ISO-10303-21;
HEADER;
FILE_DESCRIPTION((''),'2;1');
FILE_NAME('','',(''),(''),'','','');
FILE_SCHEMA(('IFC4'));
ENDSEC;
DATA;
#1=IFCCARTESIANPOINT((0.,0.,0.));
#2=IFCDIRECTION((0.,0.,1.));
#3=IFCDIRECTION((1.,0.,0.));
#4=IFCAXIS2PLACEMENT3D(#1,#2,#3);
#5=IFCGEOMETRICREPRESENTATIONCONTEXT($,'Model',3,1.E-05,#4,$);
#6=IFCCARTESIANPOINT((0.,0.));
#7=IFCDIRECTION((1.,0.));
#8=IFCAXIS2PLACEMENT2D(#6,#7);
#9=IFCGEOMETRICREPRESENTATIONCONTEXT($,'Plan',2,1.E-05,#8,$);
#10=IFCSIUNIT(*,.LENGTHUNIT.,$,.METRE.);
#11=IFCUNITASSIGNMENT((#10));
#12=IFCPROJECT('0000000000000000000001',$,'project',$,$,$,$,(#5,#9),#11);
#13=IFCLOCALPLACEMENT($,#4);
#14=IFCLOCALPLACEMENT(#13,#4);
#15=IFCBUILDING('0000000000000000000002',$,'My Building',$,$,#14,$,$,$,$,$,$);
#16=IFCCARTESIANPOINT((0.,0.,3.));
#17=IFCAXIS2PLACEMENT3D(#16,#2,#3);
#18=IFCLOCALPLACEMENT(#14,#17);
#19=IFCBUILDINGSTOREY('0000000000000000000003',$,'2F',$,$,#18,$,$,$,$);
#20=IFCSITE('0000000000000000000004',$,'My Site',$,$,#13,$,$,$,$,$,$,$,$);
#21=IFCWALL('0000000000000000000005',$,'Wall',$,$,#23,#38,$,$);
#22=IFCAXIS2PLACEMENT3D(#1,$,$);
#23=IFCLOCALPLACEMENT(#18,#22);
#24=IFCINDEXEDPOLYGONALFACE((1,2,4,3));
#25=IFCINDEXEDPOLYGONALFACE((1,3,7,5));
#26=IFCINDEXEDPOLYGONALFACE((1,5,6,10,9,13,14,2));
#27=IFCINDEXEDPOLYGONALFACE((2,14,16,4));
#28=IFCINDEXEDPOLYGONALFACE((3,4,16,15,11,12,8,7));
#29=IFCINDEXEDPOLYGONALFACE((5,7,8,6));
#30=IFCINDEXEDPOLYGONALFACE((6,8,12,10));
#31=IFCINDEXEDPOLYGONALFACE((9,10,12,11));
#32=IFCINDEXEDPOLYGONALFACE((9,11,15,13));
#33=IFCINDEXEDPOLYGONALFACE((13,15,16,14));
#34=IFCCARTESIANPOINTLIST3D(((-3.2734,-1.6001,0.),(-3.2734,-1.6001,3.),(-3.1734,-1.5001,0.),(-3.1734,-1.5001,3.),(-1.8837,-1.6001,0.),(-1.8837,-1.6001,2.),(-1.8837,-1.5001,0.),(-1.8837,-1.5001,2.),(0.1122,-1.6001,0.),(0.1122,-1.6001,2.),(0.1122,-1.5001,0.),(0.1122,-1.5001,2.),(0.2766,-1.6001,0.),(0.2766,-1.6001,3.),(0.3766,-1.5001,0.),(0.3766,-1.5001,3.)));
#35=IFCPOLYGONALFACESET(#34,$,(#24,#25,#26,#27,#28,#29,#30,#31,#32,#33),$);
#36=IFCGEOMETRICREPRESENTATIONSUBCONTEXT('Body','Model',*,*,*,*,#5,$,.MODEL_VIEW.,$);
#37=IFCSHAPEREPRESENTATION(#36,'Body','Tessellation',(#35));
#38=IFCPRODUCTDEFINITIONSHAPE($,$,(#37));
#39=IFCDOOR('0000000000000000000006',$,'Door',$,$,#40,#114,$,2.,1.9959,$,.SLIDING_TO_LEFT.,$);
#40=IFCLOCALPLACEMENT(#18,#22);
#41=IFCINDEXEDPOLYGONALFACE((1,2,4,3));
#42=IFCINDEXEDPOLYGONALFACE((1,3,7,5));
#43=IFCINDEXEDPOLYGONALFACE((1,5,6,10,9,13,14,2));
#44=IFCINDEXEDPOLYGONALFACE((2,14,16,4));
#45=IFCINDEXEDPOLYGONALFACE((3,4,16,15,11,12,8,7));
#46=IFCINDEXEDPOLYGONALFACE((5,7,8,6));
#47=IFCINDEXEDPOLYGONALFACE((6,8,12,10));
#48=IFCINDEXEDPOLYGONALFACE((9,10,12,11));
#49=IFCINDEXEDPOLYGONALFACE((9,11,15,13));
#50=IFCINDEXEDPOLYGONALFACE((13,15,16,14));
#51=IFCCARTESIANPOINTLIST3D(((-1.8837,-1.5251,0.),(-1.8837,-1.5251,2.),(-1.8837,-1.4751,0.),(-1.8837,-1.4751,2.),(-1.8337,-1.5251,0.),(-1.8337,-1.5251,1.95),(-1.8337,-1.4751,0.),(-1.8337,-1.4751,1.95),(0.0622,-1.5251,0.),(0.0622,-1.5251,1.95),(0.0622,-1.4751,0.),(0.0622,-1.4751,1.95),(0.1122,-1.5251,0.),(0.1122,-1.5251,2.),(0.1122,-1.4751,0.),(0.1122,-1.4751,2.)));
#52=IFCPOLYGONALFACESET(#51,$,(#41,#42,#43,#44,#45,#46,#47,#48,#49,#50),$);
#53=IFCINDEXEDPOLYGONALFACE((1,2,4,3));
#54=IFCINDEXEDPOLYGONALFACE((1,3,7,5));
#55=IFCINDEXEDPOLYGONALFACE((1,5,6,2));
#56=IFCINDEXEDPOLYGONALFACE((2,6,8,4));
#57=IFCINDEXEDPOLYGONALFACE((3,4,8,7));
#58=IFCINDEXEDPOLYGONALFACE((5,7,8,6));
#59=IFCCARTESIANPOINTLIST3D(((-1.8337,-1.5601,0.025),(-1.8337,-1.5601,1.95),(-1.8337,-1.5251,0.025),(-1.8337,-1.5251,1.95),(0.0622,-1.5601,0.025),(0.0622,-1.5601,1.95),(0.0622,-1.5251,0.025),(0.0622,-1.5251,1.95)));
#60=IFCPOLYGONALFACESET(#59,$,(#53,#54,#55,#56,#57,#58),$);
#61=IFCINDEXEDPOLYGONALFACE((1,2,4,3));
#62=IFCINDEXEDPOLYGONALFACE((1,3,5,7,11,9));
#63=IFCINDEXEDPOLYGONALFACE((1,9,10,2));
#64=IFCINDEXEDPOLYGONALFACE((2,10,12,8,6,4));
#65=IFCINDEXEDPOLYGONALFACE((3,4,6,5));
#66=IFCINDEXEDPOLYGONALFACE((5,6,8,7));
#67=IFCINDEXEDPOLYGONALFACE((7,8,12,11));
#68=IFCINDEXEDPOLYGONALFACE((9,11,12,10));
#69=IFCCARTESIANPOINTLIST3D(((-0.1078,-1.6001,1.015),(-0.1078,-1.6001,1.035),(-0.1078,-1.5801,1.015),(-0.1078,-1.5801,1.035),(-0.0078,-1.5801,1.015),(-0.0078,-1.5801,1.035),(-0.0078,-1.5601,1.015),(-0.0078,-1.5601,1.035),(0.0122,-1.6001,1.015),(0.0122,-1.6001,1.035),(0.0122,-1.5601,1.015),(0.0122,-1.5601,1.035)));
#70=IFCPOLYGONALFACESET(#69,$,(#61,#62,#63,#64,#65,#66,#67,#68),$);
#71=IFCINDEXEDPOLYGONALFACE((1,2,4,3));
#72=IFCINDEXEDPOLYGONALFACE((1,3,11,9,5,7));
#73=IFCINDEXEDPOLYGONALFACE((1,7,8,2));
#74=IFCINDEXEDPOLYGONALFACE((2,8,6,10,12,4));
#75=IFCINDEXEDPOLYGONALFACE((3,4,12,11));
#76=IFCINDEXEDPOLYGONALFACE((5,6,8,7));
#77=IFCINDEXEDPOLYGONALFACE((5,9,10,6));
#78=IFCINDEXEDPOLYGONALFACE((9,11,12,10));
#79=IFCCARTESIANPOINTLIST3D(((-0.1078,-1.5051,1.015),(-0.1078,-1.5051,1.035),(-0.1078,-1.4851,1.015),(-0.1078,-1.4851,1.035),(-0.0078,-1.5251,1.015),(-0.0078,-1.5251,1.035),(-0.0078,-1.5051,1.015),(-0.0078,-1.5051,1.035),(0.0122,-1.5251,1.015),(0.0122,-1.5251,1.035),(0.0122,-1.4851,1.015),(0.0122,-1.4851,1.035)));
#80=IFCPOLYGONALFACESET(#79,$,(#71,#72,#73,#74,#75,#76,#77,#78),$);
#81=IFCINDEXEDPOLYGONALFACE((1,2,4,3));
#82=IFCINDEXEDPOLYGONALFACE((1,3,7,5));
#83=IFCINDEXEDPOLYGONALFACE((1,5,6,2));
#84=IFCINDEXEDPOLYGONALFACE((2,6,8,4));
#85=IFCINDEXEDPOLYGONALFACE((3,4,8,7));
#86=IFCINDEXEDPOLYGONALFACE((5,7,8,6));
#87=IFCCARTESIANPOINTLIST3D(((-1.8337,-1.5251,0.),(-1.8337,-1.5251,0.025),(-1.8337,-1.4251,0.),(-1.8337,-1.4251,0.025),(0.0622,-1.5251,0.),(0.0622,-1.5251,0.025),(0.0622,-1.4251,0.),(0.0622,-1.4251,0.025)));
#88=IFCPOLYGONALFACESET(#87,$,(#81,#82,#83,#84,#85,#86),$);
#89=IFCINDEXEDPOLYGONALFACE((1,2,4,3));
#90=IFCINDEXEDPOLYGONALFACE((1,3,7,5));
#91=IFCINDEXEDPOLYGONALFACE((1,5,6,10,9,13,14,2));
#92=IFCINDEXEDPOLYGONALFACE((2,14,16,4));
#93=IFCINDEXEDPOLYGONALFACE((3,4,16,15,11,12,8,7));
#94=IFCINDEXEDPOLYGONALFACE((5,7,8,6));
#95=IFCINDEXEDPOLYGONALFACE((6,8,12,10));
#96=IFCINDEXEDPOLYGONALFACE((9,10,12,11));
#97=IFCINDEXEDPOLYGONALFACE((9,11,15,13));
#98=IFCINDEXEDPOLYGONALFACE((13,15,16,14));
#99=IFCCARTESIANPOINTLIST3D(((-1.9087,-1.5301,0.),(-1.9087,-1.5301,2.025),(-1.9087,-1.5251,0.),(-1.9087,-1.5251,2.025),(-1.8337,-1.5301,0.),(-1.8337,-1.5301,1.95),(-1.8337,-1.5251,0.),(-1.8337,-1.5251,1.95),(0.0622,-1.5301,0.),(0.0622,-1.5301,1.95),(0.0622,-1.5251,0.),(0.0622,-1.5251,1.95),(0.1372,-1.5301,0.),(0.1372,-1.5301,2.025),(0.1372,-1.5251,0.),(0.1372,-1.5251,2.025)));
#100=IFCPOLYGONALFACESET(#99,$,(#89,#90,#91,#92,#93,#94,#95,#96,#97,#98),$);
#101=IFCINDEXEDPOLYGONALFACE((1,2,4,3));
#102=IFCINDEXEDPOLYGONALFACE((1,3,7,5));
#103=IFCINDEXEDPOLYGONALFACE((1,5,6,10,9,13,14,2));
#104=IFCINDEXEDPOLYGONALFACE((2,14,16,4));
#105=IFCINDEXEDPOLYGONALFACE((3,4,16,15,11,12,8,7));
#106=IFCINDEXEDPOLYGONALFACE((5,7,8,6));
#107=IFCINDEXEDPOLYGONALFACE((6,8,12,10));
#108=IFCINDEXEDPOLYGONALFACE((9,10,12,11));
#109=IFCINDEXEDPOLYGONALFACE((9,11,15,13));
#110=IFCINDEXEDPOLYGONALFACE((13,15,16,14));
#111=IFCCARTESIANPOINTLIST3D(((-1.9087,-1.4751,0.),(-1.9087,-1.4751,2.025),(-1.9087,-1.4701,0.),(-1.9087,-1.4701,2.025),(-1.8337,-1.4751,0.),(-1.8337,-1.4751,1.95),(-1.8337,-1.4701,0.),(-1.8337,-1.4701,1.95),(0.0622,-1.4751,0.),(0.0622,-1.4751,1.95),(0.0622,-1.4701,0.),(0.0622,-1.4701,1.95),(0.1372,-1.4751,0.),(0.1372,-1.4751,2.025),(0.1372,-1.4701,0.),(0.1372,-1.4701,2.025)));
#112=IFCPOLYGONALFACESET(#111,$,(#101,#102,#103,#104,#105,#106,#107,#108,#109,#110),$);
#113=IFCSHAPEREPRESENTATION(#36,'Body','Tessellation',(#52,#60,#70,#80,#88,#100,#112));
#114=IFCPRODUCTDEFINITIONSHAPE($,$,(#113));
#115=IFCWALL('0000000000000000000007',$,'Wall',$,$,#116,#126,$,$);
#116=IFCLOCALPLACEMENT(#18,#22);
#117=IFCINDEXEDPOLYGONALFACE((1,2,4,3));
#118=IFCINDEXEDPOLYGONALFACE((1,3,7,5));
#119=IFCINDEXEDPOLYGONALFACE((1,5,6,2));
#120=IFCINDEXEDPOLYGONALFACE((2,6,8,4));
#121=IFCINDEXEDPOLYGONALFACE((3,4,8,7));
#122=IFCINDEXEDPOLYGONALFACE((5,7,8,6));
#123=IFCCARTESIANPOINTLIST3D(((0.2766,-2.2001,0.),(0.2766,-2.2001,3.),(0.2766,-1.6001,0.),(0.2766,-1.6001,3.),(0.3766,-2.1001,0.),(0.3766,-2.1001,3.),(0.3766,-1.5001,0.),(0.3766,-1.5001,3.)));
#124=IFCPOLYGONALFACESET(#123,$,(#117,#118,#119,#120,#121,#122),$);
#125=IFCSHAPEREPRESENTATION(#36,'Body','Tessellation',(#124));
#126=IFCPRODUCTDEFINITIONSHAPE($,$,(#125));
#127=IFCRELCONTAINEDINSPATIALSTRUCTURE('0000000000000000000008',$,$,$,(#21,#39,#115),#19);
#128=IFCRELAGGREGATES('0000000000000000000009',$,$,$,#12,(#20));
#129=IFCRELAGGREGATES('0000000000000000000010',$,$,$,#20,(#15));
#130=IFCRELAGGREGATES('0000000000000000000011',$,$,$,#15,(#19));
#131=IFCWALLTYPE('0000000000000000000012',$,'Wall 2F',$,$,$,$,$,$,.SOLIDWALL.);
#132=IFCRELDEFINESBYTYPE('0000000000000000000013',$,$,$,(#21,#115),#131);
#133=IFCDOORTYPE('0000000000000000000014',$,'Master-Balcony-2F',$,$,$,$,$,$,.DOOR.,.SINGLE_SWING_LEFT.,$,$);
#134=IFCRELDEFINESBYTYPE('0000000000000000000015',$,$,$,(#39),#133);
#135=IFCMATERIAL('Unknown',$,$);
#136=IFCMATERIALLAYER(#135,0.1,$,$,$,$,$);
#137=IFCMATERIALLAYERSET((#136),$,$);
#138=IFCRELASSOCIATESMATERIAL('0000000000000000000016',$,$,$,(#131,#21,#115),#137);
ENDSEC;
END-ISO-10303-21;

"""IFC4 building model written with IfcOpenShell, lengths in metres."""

from ifc_helpers import new_model, entity, si_unit, frame, origin_with_axes, origin_2d_with_axis, place, context, subcontext, project, spatial, line, indexed_curve, outline, extrude, shape, source, transform, mapped, material, layer, layer_set, layer_usage, type_object, type_shapes, element, fill, save


model = new_model("IFC4")

# Units and contexts
model_context = context("Model", 3, precision=1e-05, world=origin_with_axes())
plan_context = context("Plan", 2, precision=1e-05, world=origin_2d_with_axis())
body_context_1 = subcontext(model_context, "Body", "Model", "MODEL_VIEW")
body_context_2 = subcontext(plan_context, "Body", "Plan", "PLAN_VIEW")
ifc_project = project(units=[si_unit("LENGTHUNIT", "METRE")], contexts=[model_context, plan_context])

# Site, building, storey
site_placement = place(None, origin_with_axes())
site = spatial("IfcSite", under=ifc_project, at=site_placement, Name="My Site")
building_placement = place(site_placement, origin_with_axes())
building = spatial("IfcBuilding", under=site, at=building_placement, Name="My Building")
storey_placement = place(building_placement, frame((0.0, 0.0, 3.0), z_axis=(0.0, 0.0, 1.0), x_axis=(1.0, 0.0, 0.0)))
storey = spatial("IfcBuildingStorey", under=building, at=storey_placement, Name="2F")

# Shared definitions
ifc_material = material(Name="Unknown")

# Wall, opening, door
ifc_layer = layer(ifc_material, 0.1)
ifc_layer_set = layer_set([ifc_layer])
ifc_layer_usage_1 = layer_usage(ifc_layer_set, "AXIS2", "POSITIVE", 0.0)
wall_type = type_object("IfcWallType", Name="Wall 2F", PredefinedType="SOLIDWALL", material=ifc_layer_set)
wall_1_placement = place(storey_placement, frame((-3.2734, -1.6001, 0.0), z_axis=(0.0, 0.0, 1.0), x_axis=(1.0, 0.0, 0.0)))
wall_1 = element("IfcWall", 1, at=wall_1_placement, inside=storey, type_object=wall_type, material=ifc_layer_usage_1, Name="Wall", context=body_context_1, shape_type="SweptSolid", body=[
    extrude(outline(indexed_curve([(0.0, 0.0), (0.1, 0.1), (3.65, 0.1), (3.55, 0.0)], segments=[line(1, 2, 3, 4, 1)])), origin_with_axes(), (0.0, 0.0, 1.0), 3.0),
])
shared_shape_1 = source(origin_with_axes(), body_context_1, "Body", "SweptSolid", [
    extrude(outline(indexed_curve([(0.0, 0.0), (1.9959, 0.0), (1.9959, 2.0), (0.0, 2.0)], segments=[line(1, 2, 3, 4, 1)])), frame((0.0, -0.6, 0.0), z_axis=(0.0, -1.0, 0.0), x_axis=(1.0, 0.0, 0.0)), (0.0, 0.0, -1.0), 1.2),
])
opening_1_placement = place(wall_1_placement, frame((1.3897, 0.075, 0.0), z_axis=(0.0, 0.0, 1.0), x_axis=(1.0, 0.0, 0.0)))
opening_1 = element("IfcOpeningElement", 2, at=opening_1_placement, cuts=wall_1, PredefinedType="OPENING", context=body_context_1, shape_type="MappedRepresentation", body=[
    mapped(shared_shape_1, transform((0.0, 0.0, 0.0), x_axis=(1.0, 0.0, 0.0), y_axis=(0.0, 1.0, 0.0), z_axis=(0.0, 0.0, 1.0), scale=1.0)),
])
door_type_1 = type_object("IfcDoorType", Name="Master-Balcony-2F", OperationType="SINGLE_SWING_LEFT", PredefinedType="DOOR")
shared_shape_2 = source(origin_with_axes(), body_context_1, "Body", "SweptSolid", [
    extrude(outline(indexed_curve([(0.0, 0.0), (0.0, 2.0), (1.9959, 2.0), (1.9959, 0.0), (1.9459, 0.0), (1.9459, 1.95), (0.05, 1.95), (0.05, 0.0)], segments=[line(1, 2, 3, 4, 5, 6, 7, 8, 1)])), frame((0.0, 0.0, 0.0), z_axis=(0.0, -1.0, 0.0), x_axis=(1.0, 0.0, 0.0)), (0.0, 0.0, -1.0), 0.05),
    extrude(outline(indexed_curve([(0.0, 0.0), (1.8959, 0.0), (1.8959, 0.035), (0.0, 0.035)], segments=[line(1, 2, 3, 4, 1)])), frame((0.05, -0.035, 0.025), z_axis=(0.0, 0.0, 1.0), x_axis=(1.0, 0.0, 0.0)), (0.0, 0.0, 1.0), 1.925),
    extrude(outline(indexed_curve([(0.0, 0.0), (0.0, -0.04), (-0.12, -0.04), (-0.12, -0.02), (-0.02, -0.02), (-0.02, 0.0)], segments=[line(1, 2, 3, 4, 5, 6, 1)])), frame((1.8959, -0.035, 1.015), z_axis=(0.0, 0.0, 1.0), x_axis=(1.0, 0.0, 0.0)), (0.0, 0.0, 1.0), 0.02),
    extrude(outline(indexed_curve([(0.0, 0.0), (0.0, 0.04), (-0.12, 0.04), (-0.12, 0.02), (-0.02, 0.02), (-0.02, 0.0)], segments=[line(1, 2, 3, 4, 5, 6, 1)])), frame((1.8959, 0.0, 1.015), z_axis=(0.0, 0.0, 1.0), x_axis=(1.0, 0.0, 0.0)), (0.0, 0.0, 1.0), 0.02),
    extrude(outline(indexed_curve([(0.0, 0.0), (1.8959, 0.0), (1.8959, 0.1), (0.0, 0.1)], segments=[line(1, 2, 3, 4, 1)])), frame((0.05, 0.0, 0.0), z_axis=(0.0, 0.0, 1.0), x_axis=(1.0, 0.0, 0.0)), (0.0, 0.0, 1.0), 0.025),
    extrude(outline(indexed_curve([(0.0, 0.0), (0.0, 2.025), (2.0459, 2.025), (2.0459, 0.0), (1.9709, 0.0), (1.9709, 1.95), (0.075, 1.95), (0.075, 0.0)], segments=[line(1, 2, 3, 4, 5, 6, 7, 8, 1)])), frame((-0.025, -0.005, 0.0), z_axis=(0.0, -1.0, 0.0), x_axis=(1.0, 0.0, 0.0)), (0.0, 0.0, -1.0), 0.005),
    extrude(outline(indexed_curve([(0.0, 0.0), (0.0, 2.025), (2.0459, 2.025), (2.0459, 0.0), (1.9709, 0.0), (1.9709, 1.95), (0.075, 1.95), (0.075, 0.0)], segments=[line(1, 2, 3, 4, 5, 6, 7, 8, 1)])), frame((-0.025, 0.05, 0.0), z_axis=(0.0, -1.0, 0.0), x_axis=(1.0, 0.0, 0.0)), (0.0, 0.0, -1.0), 0.005),
])
shared_shape_3 = source(origin_with_axes(), body_context_2, "Body", "Curve2D", [
    entity("IfcIndexedPolyCurve", entity("IfcCartesianPointList2D", [[0.0, 0.0], [0.05, 0.0], [0.05, 0.05], [0.0, 0.05]]), [entity("IfcLineIndex", [1, 2, 3, 4, 1])]),
    entity("IfcIndexedPolyCurve", entity("IfcCartesianPointList2D", [[1.9959, 0.0], [1.9459, 0.0], [1.9459, 0.05], [1.9959, 0.05]]), [entity("IfcLineIndex", [1, 2, 3, 4, 1])]),
    entity("IfcIndexedPolyCurve", entity("IfcCartesianPointList2D", [[-0.8979, -0.035], [0.9979, -0.035], [0.9979, 0.0], [-0.8979, 0.0]]), [entity("IfcLineIndex", [1, 2, 3, 4, 1])]),
])
type_shapes(door_type_1, [shared_shape_2, shared_shape_3])
door_1_placement = place(opening_1_placement, frame((0.0, 0.0, 0.0), z_axis=(0.0, 0.0, 1.0), x_axis=(1.0, 0.0, 0.0)))
door_1 = element("IfcDoor", 3, at=door_1_placement, inside=storey, type_object=door_type_1, Name="Door", OperationType="SLIDING_TO_LEFT", OverallHeight=2.0, OverallWidth=1.9959, shapes=[
    shape(body_context_1, "Body", "MappedRepresentation", [mapped(shared_shape_2, transform((0.0, 0.0, 0.0), x_axis=(1.0, 0.0, 0.0), y_axis=(0.0, 1.0, 0.0), z_axis=(0.0, 0.0, 1.0), scale=1.0))]),
    shape(body_context_2, "Body", "MappedRepresentation", [mapped(shared_shape_3, transform((0.0, 0.0, 0.0), x_axis=(1.0, 0.0, 0.0), y_axis=(0.0, 1.0, 0.0), z_axis=(0.0, 0.0, 1.0), scale=1.0))]),
])
fill(opening_1, door_1)

# Wall
ifc_layer_usage_2 = layer_usage(ifc_layer_set, "AXIS2", "POSITIVE", 0.0)
wall_2_placement = place(storey_placement, frame((0.2766, -1.6001, 0.0), z_axis=(0.0, 0.0, 1.0), x_axis=(0.0, -1.0, 0.0)))
element("IfcWall", 4, at=wall_2_placement, inside=storey, type_object=wall_type, material=ifc_layer_usage_2, Name="Wall", context=body_context_1, shape_type="SweptSolid", body=[
    extrude(outline(indexed_curve([(0.0, 0.0), (-0.1, 0.1), (0.5, 0.1), (0.6, 0.0)], segments=[line(1, 2, 3, 4, 1)])), origin_with_axes(), (0.0, 0.0, 1.0), 3.0),
])

save(model, "model.ifc")
